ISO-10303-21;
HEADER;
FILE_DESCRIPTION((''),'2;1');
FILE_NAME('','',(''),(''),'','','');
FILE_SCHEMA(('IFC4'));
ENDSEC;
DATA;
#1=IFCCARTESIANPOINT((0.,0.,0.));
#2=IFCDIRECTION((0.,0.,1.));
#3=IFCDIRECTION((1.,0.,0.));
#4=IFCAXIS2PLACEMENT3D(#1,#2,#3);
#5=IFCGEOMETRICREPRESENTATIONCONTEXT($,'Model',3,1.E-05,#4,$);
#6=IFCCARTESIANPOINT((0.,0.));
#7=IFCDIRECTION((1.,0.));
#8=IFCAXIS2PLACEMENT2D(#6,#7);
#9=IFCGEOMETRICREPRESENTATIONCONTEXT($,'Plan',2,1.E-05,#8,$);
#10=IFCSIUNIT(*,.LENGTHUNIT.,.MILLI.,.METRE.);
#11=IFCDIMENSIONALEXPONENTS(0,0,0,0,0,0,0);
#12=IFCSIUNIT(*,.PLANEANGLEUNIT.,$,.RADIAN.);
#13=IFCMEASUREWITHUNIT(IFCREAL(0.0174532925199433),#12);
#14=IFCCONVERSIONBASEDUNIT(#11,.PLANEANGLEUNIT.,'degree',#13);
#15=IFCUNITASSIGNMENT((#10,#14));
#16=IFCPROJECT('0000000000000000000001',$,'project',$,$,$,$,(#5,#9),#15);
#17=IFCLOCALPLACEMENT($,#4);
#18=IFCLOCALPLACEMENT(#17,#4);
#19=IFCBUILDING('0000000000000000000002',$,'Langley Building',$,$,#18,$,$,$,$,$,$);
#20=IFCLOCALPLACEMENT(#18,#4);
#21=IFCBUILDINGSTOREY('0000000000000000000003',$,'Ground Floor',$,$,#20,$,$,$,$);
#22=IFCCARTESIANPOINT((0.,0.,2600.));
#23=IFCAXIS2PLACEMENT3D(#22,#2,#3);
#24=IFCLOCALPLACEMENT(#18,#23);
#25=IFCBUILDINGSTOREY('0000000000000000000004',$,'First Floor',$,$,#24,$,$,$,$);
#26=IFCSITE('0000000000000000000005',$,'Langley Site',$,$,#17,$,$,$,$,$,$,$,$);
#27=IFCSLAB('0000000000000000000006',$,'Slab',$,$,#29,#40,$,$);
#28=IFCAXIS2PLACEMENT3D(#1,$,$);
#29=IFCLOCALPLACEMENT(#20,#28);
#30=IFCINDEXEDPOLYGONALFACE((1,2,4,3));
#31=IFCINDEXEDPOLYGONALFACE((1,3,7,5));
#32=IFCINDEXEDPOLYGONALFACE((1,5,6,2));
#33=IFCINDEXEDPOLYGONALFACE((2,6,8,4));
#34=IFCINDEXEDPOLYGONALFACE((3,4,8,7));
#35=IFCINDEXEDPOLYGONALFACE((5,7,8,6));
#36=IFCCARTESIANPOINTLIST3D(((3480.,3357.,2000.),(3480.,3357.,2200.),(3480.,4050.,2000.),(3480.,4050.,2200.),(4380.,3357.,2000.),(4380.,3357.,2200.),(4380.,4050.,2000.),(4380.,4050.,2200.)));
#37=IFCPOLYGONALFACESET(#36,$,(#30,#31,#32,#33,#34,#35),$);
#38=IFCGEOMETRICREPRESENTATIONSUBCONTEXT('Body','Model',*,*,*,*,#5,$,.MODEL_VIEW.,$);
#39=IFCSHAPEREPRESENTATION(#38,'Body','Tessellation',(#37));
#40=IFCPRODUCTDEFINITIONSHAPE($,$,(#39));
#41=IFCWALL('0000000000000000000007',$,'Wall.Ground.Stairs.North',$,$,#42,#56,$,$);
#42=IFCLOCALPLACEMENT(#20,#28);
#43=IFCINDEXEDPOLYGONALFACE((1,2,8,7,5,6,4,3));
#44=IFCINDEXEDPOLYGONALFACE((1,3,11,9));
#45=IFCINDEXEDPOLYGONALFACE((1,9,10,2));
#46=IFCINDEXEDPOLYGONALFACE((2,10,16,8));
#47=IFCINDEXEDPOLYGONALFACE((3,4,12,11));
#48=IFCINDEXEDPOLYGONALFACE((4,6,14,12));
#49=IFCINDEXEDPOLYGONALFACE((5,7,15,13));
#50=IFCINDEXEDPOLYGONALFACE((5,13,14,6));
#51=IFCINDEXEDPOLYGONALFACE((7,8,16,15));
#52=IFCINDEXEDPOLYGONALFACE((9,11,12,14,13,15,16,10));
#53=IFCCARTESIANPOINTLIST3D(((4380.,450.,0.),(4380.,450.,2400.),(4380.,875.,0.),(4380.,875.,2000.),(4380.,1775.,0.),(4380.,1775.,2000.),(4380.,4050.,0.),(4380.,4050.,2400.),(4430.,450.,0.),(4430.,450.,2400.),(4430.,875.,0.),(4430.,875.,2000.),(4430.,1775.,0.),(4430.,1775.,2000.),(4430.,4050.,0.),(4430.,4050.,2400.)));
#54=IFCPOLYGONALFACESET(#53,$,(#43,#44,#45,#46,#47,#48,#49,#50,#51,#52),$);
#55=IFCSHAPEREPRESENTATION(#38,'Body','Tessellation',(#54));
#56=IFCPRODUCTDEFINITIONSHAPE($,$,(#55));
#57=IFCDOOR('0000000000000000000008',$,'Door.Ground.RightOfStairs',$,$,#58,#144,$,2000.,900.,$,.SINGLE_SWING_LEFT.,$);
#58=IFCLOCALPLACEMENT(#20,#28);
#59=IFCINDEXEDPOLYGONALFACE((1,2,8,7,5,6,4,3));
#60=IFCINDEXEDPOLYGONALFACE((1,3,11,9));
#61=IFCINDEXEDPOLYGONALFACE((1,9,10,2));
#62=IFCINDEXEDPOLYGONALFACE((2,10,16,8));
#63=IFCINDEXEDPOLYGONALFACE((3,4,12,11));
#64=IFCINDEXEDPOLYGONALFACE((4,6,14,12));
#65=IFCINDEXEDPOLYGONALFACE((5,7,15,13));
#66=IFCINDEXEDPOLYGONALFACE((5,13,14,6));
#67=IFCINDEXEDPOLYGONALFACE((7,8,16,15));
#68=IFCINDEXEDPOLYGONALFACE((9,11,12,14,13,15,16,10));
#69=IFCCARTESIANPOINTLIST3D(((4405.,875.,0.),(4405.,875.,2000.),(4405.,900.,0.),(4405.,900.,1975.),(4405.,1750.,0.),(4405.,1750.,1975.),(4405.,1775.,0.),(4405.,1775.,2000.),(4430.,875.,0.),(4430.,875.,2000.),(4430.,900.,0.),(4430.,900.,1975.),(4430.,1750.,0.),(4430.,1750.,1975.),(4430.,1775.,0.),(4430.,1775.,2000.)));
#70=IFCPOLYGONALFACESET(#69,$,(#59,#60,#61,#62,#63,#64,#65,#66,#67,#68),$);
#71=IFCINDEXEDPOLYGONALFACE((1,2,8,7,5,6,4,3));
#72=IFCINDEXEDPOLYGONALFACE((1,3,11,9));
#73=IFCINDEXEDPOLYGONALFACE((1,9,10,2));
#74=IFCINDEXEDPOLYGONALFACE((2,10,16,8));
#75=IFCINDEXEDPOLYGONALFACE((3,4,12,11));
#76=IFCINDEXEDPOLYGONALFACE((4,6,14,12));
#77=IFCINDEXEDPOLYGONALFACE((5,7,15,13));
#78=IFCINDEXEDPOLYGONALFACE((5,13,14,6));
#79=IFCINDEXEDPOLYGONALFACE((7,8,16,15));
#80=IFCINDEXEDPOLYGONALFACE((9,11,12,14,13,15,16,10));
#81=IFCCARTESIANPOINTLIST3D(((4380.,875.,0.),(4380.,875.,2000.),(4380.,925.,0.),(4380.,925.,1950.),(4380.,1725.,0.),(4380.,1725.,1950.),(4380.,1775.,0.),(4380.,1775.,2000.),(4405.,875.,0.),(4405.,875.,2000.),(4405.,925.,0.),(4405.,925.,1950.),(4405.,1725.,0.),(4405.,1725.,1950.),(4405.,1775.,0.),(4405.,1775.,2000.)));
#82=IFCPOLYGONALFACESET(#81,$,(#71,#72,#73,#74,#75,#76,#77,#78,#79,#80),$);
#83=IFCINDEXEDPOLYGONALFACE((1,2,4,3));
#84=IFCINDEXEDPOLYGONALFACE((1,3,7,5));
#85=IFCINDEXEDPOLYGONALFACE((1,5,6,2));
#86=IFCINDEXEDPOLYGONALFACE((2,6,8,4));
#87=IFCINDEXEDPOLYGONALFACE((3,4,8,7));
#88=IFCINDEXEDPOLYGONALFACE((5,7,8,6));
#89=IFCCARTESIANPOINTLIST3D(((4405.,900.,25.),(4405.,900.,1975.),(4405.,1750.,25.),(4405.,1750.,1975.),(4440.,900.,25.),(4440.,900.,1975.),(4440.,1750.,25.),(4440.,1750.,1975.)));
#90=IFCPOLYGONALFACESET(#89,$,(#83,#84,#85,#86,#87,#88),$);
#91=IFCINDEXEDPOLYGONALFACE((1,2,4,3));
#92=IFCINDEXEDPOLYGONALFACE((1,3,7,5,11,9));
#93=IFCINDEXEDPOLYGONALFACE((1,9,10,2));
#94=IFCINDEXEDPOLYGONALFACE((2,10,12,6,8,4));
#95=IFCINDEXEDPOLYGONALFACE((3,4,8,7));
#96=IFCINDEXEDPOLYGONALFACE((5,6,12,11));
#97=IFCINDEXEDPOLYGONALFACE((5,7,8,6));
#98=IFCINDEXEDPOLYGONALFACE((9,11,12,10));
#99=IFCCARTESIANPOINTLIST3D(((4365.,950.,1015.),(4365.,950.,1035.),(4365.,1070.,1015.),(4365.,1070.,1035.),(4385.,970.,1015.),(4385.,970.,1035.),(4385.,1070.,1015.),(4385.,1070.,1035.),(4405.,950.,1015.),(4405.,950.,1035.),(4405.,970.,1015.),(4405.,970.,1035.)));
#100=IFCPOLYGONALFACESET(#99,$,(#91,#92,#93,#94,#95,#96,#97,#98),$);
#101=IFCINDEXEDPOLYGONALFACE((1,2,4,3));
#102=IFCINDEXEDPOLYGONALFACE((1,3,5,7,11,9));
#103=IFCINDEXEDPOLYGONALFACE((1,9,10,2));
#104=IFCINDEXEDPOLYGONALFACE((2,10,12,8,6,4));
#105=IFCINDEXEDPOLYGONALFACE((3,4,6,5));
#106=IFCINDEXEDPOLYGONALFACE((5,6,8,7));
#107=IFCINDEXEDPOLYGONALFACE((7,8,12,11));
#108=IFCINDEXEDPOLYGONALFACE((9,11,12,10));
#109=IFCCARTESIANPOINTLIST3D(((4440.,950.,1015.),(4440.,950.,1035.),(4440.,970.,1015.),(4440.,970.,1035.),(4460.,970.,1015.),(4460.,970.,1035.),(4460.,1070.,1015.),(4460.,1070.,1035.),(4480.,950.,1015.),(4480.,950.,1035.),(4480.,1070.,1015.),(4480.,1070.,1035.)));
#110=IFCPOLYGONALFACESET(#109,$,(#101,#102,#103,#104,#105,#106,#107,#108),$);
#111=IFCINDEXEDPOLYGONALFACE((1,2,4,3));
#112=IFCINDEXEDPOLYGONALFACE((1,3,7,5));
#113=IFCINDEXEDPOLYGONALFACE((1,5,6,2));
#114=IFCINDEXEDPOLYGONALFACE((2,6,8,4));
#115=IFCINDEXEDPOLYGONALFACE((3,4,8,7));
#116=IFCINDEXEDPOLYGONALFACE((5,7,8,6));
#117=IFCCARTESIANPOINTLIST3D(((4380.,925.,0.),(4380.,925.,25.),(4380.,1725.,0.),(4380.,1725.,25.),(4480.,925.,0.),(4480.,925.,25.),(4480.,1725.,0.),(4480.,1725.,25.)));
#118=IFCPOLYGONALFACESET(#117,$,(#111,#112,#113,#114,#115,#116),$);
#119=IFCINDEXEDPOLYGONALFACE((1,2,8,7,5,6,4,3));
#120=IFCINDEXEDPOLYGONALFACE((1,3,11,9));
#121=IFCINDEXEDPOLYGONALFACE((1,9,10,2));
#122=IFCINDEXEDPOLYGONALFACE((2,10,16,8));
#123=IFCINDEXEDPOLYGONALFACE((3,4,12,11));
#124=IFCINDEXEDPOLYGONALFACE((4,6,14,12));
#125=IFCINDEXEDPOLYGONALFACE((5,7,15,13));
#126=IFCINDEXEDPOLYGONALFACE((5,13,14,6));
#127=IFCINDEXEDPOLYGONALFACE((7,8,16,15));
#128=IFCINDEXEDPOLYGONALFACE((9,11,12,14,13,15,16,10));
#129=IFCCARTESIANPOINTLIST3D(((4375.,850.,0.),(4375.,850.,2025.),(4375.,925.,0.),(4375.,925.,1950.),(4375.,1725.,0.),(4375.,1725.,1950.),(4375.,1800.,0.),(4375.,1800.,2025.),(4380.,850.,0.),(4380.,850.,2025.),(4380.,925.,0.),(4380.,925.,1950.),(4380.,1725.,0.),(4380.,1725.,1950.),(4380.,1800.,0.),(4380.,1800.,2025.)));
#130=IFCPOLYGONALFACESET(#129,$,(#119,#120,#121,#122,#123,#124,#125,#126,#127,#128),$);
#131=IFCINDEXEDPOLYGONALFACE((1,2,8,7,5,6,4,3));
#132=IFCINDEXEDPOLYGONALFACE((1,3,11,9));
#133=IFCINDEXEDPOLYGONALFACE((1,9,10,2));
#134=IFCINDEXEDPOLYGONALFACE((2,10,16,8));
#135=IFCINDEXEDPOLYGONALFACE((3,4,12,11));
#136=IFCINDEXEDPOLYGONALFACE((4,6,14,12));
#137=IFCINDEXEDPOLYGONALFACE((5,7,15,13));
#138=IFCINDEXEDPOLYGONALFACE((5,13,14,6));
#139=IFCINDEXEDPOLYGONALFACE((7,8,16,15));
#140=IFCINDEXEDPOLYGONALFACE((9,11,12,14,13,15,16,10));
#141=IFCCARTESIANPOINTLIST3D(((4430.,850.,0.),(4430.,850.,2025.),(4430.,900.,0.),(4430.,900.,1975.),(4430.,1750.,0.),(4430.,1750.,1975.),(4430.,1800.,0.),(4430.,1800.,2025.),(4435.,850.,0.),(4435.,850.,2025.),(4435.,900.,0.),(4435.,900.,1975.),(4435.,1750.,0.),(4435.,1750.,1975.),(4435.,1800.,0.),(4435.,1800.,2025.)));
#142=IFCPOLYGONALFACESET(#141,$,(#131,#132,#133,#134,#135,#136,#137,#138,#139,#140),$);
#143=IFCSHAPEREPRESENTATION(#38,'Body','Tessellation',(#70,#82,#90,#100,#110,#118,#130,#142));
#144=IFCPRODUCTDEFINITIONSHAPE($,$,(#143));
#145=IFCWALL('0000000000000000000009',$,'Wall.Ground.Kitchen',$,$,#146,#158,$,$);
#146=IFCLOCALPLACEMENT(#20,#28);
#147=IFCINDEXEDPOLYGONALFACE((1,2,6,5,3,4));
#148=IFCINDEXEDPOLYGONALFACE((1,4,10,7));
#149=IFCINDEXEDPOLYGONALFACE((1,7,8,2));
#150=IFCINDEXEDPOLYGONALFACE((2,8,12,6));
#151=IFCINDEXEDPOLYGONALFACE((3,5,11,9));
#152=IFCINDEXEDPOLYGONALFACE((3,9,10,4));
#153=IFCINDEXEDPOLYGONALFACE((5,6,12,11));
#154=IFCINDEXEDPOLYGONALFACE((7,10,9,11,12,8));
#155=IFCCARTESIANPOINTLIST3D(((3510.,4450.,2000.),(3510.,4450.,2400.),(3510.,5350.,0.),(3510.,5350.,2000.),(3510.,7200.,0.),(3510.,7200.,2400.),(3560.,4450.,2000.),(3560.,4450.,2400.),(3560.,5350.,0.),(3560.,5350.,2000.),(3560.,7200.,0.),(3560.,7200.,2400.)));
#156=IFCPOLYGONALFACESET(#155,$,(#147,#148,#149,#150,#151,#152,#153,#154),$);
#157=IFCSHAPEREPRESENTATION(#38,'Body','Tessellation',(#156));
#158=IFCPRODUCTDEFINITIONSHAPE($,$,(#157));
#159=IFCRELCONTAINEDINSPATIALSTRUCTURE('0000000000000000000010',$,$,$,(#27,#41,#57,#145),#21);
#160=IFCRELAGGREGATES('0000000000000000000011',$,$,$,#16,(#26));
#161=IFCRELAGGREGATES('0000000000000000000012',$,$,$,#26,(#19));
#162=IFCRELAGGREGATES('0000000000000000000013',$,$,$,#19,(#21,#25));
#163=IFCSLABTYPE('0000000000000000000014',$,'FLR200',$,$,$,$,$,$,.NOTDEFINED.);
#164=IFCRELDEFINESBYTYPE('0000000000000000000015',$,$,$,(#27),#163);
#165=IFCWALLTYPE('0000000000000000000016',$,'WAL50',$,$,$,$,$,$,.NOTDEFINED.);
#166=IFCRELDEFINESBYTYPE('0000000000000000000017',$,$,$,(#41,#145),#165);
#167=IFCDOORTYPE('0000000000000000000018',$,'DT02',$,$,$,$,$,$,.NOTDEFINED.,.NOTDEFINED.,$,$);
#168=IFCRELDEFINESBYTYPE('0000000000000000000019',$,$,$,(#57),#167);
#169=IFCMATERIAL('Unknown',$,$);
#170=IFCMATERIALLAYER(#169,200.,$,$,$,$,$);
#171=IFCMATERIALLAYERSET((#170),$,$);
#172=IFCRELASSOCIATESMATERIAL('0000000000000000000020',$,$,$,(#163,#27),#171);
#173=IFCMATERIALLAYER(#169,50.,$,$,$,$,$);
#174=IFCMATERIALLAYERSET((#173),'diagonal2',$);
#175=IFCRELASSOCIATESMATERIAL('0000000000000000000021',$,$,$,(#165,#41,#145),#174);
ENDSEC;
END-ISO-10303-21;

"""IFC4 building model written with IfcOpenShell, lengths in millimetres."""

from ifc_helpers import new_model, entity, si_unit, converted_unit, frame, origin_with_axes, origin_2d_with_axis, place, context, subcontext, project, spatial, line, indexed_curve, outline, extrude, shape, source, transform, mapped, material, layer, layer_set, layer_usage, type_object, type_shapes, element, fill, save


model = new_model("IFC4")

# Units and contexts
model_context = context("Model", 3, precision=1e-05, world=origin_with_axes())
plan_context = context("Plan", 2, precision=1e-05, world=origin_2d_with_axis())
body_context_1 = subcontext(model_context, "Body", "Model", "MODEL_VIEW")
body_context_2 = subcontext(plan_context, "Body", "Plan", "PLAN_VIEW")
ifc_project = project(units=[si_unit("LENGTHUNIT", "METRE", prefix="MILLI"), converted_unit("PLANEANGLEUNIT", "degree", entity("IfcReal", 0.0174532925199433), si_unit("PLANEANGLEUNIT", "RADIAN"), dimensions=[0, 0, 0, 0, 0, 0, 0])], contexts=[model_context, plan_context])

# Site, building, storey
site_placement = place(None, origin_with_axes())
site = spatial("IfcSite", under=ifc_project, at=site_placement, Name="Langley Site")
building_placement = place(site_placement, origin_with_axes())
building = spatial("IfcBuilding", under=site, at=building_placement, Name="Langley Building")
storey_1_placement = place(building_placement, origin_with_axes())
storey_1 = spatial("IfcBuildingStorey", under=building, at=storey_1_placement, Name="Ground Floor")

# Slab
ifc_material = material(Name="Unknown")
ifc_layer_1 = layer(ifc_material, 200.0)
ifc_layer_set_1 = layer_set([ifc_layer_1])
ifc_layer_usage_1 = layer_usage(ifc_layer_set_1, "AXIS3", "POSITIVE", -200.0)
slab_type = type_object("IfcSlabType", Name="FLR200", PredefinedType="NOTDEFINED", material=ifc_layer_set_1)
slab_placement = place(storey_1_placement, frame((4380.0, 4050.0, 2200.0), z_axis=(0.0, 0.0, 1.0), x_axis=(1.0, 0.0, 0.0)))
element("IfcSlab", 1, at=slab_placement, inside=storey_1, type_object=slab_type, material=ifc_layer_usage_1, Name="Slab", context=body_context_1, shape_type="SweptSolid", body=[
    extrude(outline(indexed_curve([(0.0, 0.0), (-900.0, 0.0), (-900.0, -693.0), (0.0, -693.0), (0.0, 0.0)])), frame((0.0, 0.0, -200.0), z_axis=(0.0, 0.0, 1.0), x_axis=(1.0, 0.0, 0.0)), (0.0, 0.0, 1.0), 200.0),
])

# Wall, opening
ifc_layer_2 = layer(ifc_material, 50.0)
ifc_layer_set_2 = layer_set([ifc_layer_2], Name="diagonal2")
ifc_layer_usage_2 = layer_usage(ifc_layer_set_2, "AXIS2", "POSITIVE", 0.0)
wall_type_1 = type_object("IfcWallType", Name="WAL50", PredefinedType="NOTDEFINED", material=ifc_layer_set_2)
wall_1_placement = place(storey_1_placement, frame((4380.0, 4050.0, 0.0), z_axis=(0.0, 0.0, 1.0), x_axis=(0.0, -1.0, 0.0)))
wall_1 = element("IfcWall", 2, at=wall_1_placement, inside=storey_1, type_object=wall_type_1, material=ifc_layer_usage_2, Name="Wall.Ground.Stairs.North", context=body_context_1, shape_type="SweptSolid", body=[
    extrude(outline(indexed_curve([(0.0, 0.0), (0.0, 50.0), (3600.0, 50.0), (3600.0, 0.0)], segments=[line(1, 2, 3, 4, 1)])), origin_with_axes(), (0.0, 0.0, 1.0), 2400.0),
])
shared_shape_1 = source(origin_with_axes(), body_context_1, "Body", "SweptSolid", [
    extrude(outline(indexed_curve([(0.0, 0.0), (900.0, 0.0), (900.0, 2000.0), (0.0, 2000.0)], segments=[line(1, 2, 3, 4, 1)])), frame((0.0, -600.0, 0.0), z_axis=(0.0, -1.0, 0.0), x_axis=(1.0, 0.0, 0.0)), (0.0, 0.0, -1.0), 1200.0),
])
opening_1_placement = place(wall_1_placement, frame((2275.0, 0.0, 0.0), z_axis=(0.0, 0.0, 1.0), x_axis=(1.0, 0.0, 0.0)))
opening_1 = element("IfcOpeningElement", 3, at=opening_1_placement, cuts=wall_1, PredefinedType="OPENING", context=body_context_1, shape_type="MappedRepresentation", body=[
    mapped(shared_shape_1, transform((0.0, 0.0, 0.0), x_axis=(1.0, 0.0, 0.0), y_axis=(0.0, 1.0, 0.0), z_axis=(0.0, 0.0, 1.0), scale=1.0)),
])

# Shared definitions
storey_2_placement = place(building_placement, frame((0.0, 0.0, 2600.0), z_axis=(0.0, 0.0, 1.0), x_axis=(1.0, 0.0, 0.0)))
storey_2 = spatial("IfcBuildingStorey", under=building, at=storey_2_placement, Name="First Floor")

# Opening
shared_shape_2 = source(origin_with_axes(), body_context_1, "Body", "SweptSolid", [
    extrude(outline(indexed_curve([(0.0, 0.0), (900.0, 0.0), (900.0, 2000.0), (0.0, 2000.0)], segments=[line(1, 2, 3, 4, 1)])), frame((0.0, -600.0, 0.0), z_axis=(0.0, -1.0, 0.0), x_axis=(1.0, 0.0, 0.0)), (0.0, 0.0, -1.0), 1200.0),
])
opening_2_placement = place(wall_1_placement, frame((2290.0, 0.0, 2600.0), z_axis=(0.0, 0.0, 1.0), x_axis=(1.0, 0.0, 0.0)))
element("IfcOpeningElement", 4, at=opening_2_placement, inside=storey_2, cuts=wall_1, PredefinedType="OPENING", context=body_context_1, shape_type="MappedRepresentation", body=[
    mapped(shared_shape_2, transform((0.0, 0.0, 0.0), x_axis=(1.0, 0.0, 0.0), y_axis=(0.0, 1.0, 0.0), z_axis=(0.0, 0.0, 1.0), scale=1.0)),
])

# Door
door_type_1 = type_object("IfcDoorType", Name="DT02", OperationType="NOTDEFINED", PredefinedType="NOTDEFINED")
shared_shape_3 = source(origin_with_axes(), body_context_1, "Body", "SweptSolid", [
    extrude(outline(indexed_curve([(0.0, 0.0), (0.0, 2000.0), (900.0, 2000.0), (900.0, 0.0), (875.0, 0.0), (875.0, 1975.0), (25.0, 1975.0), (25.0, 0.0)], segments=[line(1, 2, 3, 4, 5, 6, 7, 8, 1)])), frame((0.0, 25.0, 0.0), z_axis=(0.0, -1.0, 0.0), x_axis=(1.0, 0.0, 0.0)), (0.0, 0.0, -1.0), 25.0),
    extrude(outline(indexed_curve([(0.0, 0.0), (0.0, 2000.0), (900.0, 2000.0), (900.0, 0.0), (850.0, 0.0), (850.0, 1950.0), (50.0, 1950.0), (50.0, 0.0)], segments=[line(1, 2, 3, 4, 5, 6, 7, 8, 1)])), frame((0.0, 0.0, 0.0), z_axis=(0.0, -1.0, 0.0), x_axis=(1.0, 0.0, 0.0)), (0.0, 0.0, -1.0), 25.0),
    extrude(outline(indexed_curve([(0.0, 0.0), (850.0, 0.0), (850.0, 35.0), (0.0, 35.0)], segments=[line(1, 2, 3, 4, 1)])), frame((25.0, 25.0, 25.0), z_axis=(0.0, 0.0, 1.0), x_axis=(1.0, 0.0, 0.0)), (0.0, 0.0, 1.0), 1950.0),
    extrude(outline(indexed_curve([(0.0, 0.0), (0.0, -40.0), (-120.0, -40.0), (-120.0, -20.0), (-20.0, -20.0), (-20.0, 0.0)], segments=[line(1, 2, 3, 4, 5, 6, 1)])), frame((825.0, 25.0, 1015.0), z_axis=(0.0, 0.0, 1.0), x_axis=(1.0, 0.0, 0.0)), (0.0, 0.0, 1.0), 20.0),
    extrude(outline(indexed_curve([(0.0, 0.0), (0.0, 40.0), (-120.0, 40.0), (-120.0, 20.0), (-20.0, 20.0), (-20.0, 0.0)], segments=[line(1, 2, 3, 4, 5, 6, 1)])), frame((825.0, 60.0, 1015.0), z_axis=(0.0, 0.0, 1.0), x_axis=(1.0, 0.0, 0.0)), (0.0, 0.0, 1.0), 20.0),
    extrude(outline(indexed_curve([(0.0, 0.0), (800.0, 0.0), (800.0, 100.0), (0.0, 100.0)], segments=[line(1, 2, 3, 4, 1)])), frame((50.0, 0.0, 0.0), z_axis=(0.0, 0.0, 1.0), x_axis=(1.0, 0.0, 0.0)), (0.0, 0.0, 1.0), 25.0),
    extrude(outline(indexed_curve([(0.0, 0.0), (0.0, 2025.0), (950.0, 2025.0), (950.0, 0.0), (875.0, 0.0), (875.0, 1950.0), (75.0, 1950.0), (75.0, 0.0)], segments=[line(1, 2, 3, 4, 5, 6, 7, 8, 1)])), frame((-25.0, -5.0, 0.0), z_axis=(0.0, -1.0, 0.0), x_axis=(1.0, 0.0, 0.0)), (0.0, 0.0, -1.0), 5.0),
    extrude(outline(indexed_curve([(0.0, 0.0), (0.0, 2025.0), (950.0, 2025.0), (950.0, 0.0), (900.0, 0.0), (900.0, 1975.0), (50.0, 1975.0), (50.0, 0.0)], segments=[line(1, 2, 3, 4, 5, 6, 7, 8, 1)])), frame((-25.0, 50.0, 0.0), z_axis=(0.0, -1.0, 0.0), x_axis=(1.0, 0.0, 0.0)), (0.0, 0.0, -1.0), 5.0),
])
shared_shape_4 = source(origin_with_axes(), body_context_2, "Body", "Curve2D", [
    entity("IfcIndexedPolyCurve", entity("IfcCartesianPointList2D", [[0.0, 0.0], [0.0, 50.0], [25.0, 50.0], [25.0, 25.0], [50.0, 25.0], [50.0, 0.0]]), [entity("IfcLineIndex", [1, 2, 3, 4, 5, 6, 1])]),
    entity("IfcIndexedPolyCurve", entity("IfcCartesianPointList2D", [[900.0, 0.0], [900.0, 50.0], [875.0, 50.0], [875.0, 25.0], [850.0, 25.0], [850.0, 0.0]]), [entity("IfcLineIndex", [1, 2, 3, 4, 5, 6, 1])]),
    entity("IfcTrimmedCurve", entity("IfcEllipse", entity("IfcAxis2Placement2D", entity("IfcCartesianPoint", [60.0, 50.0]), entity("IfcDirection", [1.0, 0.0])), 815.0, 850.0), [entity("IfcCartesianPoint", [875.0, 50.0])], [entity("IfcCartesianPoint", [60.0, 900.0])], True, "CARTESIAN"),
    entity("IfcIndexedPolyCurve", entity("IfcCartesianPointList2D", [[25.0, 50.0], [60.0, 50.0], [60.0, 900.0], [25.0, 900.0]]), [entity("IfcLineIndex", [1, 2, 3, 4, 1])]),
])
type_shapes(door_type_1, [shared_shape_3, shared_shape_4])
door_1_placement = place(opening_1_placement, frame((0.0, 0.0, 0.0), z_axis=(0.0, 0.0, 1.0), x_axis=(1.0, 0.0, 0.0)))
door_1 = element("IfcDoor", 5, at=door_1_placement, inside=storey_1, type_object=door_type_1, Name="Door.Ground.RightOfStairs", OperationType="SINGLE_SWING_LEFT", OverallHeight=2000.0, OverallWidth=900.0, shapes=[
    shape(body_context_1, "Body", "MappedRepresentation", [mapped(shared_shape_3, transform((0.0, 0.0, 0.0), x_axis=(1.0, 0.0, 0.0), y_axis=(0.0, 1.0, 0.0), z_axis=(0.0, 0.0, 1.0), scale=1.0))]),
    shape(body_context_2, "Body", "MappedRepresentation", [mapped(shared_shape_4, transform((0.0, 0.0, 0.0), x_axis=(1.0, 0.0, 0.0), y_axis=(0.0, 1.0, 0.0), z_axis=(0.0, 0.0, 1.0), scale=1.0))]),
])
fill(opening_1, door_1)

# Wall, opening
ifc_layer_usage_3 = layer_usage(ifc_layer_set_2, "AXIS2", "POSITIVE", 0.0)
wall_2_placement = place(storey_1_placement, frame((3560.0, 4450.0, 0.0), z_axis=(0.0, 0.0, 1.0), x_axis=(0.0, 1.0, 0.0)))
wall_2 = element("IfcWall", 6, at=wall_2_placement, inside=storey_1, type_object=wall_type_1, material=ifc_layer_usage_3, Name="Wall.Ground.Kitchen", context=body_context_1, shape_type="SweptSolid", body=[
    extrude(outline(indexed_curve([(0.0, 0.0), (0.0, 50.0), (2750.0, 50.0), (2750.0, 0.0)], segments=[line(1, 2, 3, 4, 1)])), origin_with_axes(), (0.0, 0.0, 1.0), 2400.0),
])
opening_3_placement = place(wall_2_placement, frame((0.0, 58.5, 0.0), z_axis=(0.0, 0.0, 1.0), x_axis=(0.0, -1.0, 0.0)))
element("IfcOpeningElement", 7, at=opening_3_placement, cuts=wall_2, PredefinedType="OPENING", context=body_context_1, shape_type="SweptSolid", body=[
    extrude(outline(indexed_curve([(-50.0, 900.0), (99.7, 900.0), (99.7, 0.0), (-50.0, 0.0), (-50.0, 900.0)])), origin_with_axes(), (0.0, 0.0, 1.0), 2000.0),
])

save(model, "model.ifc")
